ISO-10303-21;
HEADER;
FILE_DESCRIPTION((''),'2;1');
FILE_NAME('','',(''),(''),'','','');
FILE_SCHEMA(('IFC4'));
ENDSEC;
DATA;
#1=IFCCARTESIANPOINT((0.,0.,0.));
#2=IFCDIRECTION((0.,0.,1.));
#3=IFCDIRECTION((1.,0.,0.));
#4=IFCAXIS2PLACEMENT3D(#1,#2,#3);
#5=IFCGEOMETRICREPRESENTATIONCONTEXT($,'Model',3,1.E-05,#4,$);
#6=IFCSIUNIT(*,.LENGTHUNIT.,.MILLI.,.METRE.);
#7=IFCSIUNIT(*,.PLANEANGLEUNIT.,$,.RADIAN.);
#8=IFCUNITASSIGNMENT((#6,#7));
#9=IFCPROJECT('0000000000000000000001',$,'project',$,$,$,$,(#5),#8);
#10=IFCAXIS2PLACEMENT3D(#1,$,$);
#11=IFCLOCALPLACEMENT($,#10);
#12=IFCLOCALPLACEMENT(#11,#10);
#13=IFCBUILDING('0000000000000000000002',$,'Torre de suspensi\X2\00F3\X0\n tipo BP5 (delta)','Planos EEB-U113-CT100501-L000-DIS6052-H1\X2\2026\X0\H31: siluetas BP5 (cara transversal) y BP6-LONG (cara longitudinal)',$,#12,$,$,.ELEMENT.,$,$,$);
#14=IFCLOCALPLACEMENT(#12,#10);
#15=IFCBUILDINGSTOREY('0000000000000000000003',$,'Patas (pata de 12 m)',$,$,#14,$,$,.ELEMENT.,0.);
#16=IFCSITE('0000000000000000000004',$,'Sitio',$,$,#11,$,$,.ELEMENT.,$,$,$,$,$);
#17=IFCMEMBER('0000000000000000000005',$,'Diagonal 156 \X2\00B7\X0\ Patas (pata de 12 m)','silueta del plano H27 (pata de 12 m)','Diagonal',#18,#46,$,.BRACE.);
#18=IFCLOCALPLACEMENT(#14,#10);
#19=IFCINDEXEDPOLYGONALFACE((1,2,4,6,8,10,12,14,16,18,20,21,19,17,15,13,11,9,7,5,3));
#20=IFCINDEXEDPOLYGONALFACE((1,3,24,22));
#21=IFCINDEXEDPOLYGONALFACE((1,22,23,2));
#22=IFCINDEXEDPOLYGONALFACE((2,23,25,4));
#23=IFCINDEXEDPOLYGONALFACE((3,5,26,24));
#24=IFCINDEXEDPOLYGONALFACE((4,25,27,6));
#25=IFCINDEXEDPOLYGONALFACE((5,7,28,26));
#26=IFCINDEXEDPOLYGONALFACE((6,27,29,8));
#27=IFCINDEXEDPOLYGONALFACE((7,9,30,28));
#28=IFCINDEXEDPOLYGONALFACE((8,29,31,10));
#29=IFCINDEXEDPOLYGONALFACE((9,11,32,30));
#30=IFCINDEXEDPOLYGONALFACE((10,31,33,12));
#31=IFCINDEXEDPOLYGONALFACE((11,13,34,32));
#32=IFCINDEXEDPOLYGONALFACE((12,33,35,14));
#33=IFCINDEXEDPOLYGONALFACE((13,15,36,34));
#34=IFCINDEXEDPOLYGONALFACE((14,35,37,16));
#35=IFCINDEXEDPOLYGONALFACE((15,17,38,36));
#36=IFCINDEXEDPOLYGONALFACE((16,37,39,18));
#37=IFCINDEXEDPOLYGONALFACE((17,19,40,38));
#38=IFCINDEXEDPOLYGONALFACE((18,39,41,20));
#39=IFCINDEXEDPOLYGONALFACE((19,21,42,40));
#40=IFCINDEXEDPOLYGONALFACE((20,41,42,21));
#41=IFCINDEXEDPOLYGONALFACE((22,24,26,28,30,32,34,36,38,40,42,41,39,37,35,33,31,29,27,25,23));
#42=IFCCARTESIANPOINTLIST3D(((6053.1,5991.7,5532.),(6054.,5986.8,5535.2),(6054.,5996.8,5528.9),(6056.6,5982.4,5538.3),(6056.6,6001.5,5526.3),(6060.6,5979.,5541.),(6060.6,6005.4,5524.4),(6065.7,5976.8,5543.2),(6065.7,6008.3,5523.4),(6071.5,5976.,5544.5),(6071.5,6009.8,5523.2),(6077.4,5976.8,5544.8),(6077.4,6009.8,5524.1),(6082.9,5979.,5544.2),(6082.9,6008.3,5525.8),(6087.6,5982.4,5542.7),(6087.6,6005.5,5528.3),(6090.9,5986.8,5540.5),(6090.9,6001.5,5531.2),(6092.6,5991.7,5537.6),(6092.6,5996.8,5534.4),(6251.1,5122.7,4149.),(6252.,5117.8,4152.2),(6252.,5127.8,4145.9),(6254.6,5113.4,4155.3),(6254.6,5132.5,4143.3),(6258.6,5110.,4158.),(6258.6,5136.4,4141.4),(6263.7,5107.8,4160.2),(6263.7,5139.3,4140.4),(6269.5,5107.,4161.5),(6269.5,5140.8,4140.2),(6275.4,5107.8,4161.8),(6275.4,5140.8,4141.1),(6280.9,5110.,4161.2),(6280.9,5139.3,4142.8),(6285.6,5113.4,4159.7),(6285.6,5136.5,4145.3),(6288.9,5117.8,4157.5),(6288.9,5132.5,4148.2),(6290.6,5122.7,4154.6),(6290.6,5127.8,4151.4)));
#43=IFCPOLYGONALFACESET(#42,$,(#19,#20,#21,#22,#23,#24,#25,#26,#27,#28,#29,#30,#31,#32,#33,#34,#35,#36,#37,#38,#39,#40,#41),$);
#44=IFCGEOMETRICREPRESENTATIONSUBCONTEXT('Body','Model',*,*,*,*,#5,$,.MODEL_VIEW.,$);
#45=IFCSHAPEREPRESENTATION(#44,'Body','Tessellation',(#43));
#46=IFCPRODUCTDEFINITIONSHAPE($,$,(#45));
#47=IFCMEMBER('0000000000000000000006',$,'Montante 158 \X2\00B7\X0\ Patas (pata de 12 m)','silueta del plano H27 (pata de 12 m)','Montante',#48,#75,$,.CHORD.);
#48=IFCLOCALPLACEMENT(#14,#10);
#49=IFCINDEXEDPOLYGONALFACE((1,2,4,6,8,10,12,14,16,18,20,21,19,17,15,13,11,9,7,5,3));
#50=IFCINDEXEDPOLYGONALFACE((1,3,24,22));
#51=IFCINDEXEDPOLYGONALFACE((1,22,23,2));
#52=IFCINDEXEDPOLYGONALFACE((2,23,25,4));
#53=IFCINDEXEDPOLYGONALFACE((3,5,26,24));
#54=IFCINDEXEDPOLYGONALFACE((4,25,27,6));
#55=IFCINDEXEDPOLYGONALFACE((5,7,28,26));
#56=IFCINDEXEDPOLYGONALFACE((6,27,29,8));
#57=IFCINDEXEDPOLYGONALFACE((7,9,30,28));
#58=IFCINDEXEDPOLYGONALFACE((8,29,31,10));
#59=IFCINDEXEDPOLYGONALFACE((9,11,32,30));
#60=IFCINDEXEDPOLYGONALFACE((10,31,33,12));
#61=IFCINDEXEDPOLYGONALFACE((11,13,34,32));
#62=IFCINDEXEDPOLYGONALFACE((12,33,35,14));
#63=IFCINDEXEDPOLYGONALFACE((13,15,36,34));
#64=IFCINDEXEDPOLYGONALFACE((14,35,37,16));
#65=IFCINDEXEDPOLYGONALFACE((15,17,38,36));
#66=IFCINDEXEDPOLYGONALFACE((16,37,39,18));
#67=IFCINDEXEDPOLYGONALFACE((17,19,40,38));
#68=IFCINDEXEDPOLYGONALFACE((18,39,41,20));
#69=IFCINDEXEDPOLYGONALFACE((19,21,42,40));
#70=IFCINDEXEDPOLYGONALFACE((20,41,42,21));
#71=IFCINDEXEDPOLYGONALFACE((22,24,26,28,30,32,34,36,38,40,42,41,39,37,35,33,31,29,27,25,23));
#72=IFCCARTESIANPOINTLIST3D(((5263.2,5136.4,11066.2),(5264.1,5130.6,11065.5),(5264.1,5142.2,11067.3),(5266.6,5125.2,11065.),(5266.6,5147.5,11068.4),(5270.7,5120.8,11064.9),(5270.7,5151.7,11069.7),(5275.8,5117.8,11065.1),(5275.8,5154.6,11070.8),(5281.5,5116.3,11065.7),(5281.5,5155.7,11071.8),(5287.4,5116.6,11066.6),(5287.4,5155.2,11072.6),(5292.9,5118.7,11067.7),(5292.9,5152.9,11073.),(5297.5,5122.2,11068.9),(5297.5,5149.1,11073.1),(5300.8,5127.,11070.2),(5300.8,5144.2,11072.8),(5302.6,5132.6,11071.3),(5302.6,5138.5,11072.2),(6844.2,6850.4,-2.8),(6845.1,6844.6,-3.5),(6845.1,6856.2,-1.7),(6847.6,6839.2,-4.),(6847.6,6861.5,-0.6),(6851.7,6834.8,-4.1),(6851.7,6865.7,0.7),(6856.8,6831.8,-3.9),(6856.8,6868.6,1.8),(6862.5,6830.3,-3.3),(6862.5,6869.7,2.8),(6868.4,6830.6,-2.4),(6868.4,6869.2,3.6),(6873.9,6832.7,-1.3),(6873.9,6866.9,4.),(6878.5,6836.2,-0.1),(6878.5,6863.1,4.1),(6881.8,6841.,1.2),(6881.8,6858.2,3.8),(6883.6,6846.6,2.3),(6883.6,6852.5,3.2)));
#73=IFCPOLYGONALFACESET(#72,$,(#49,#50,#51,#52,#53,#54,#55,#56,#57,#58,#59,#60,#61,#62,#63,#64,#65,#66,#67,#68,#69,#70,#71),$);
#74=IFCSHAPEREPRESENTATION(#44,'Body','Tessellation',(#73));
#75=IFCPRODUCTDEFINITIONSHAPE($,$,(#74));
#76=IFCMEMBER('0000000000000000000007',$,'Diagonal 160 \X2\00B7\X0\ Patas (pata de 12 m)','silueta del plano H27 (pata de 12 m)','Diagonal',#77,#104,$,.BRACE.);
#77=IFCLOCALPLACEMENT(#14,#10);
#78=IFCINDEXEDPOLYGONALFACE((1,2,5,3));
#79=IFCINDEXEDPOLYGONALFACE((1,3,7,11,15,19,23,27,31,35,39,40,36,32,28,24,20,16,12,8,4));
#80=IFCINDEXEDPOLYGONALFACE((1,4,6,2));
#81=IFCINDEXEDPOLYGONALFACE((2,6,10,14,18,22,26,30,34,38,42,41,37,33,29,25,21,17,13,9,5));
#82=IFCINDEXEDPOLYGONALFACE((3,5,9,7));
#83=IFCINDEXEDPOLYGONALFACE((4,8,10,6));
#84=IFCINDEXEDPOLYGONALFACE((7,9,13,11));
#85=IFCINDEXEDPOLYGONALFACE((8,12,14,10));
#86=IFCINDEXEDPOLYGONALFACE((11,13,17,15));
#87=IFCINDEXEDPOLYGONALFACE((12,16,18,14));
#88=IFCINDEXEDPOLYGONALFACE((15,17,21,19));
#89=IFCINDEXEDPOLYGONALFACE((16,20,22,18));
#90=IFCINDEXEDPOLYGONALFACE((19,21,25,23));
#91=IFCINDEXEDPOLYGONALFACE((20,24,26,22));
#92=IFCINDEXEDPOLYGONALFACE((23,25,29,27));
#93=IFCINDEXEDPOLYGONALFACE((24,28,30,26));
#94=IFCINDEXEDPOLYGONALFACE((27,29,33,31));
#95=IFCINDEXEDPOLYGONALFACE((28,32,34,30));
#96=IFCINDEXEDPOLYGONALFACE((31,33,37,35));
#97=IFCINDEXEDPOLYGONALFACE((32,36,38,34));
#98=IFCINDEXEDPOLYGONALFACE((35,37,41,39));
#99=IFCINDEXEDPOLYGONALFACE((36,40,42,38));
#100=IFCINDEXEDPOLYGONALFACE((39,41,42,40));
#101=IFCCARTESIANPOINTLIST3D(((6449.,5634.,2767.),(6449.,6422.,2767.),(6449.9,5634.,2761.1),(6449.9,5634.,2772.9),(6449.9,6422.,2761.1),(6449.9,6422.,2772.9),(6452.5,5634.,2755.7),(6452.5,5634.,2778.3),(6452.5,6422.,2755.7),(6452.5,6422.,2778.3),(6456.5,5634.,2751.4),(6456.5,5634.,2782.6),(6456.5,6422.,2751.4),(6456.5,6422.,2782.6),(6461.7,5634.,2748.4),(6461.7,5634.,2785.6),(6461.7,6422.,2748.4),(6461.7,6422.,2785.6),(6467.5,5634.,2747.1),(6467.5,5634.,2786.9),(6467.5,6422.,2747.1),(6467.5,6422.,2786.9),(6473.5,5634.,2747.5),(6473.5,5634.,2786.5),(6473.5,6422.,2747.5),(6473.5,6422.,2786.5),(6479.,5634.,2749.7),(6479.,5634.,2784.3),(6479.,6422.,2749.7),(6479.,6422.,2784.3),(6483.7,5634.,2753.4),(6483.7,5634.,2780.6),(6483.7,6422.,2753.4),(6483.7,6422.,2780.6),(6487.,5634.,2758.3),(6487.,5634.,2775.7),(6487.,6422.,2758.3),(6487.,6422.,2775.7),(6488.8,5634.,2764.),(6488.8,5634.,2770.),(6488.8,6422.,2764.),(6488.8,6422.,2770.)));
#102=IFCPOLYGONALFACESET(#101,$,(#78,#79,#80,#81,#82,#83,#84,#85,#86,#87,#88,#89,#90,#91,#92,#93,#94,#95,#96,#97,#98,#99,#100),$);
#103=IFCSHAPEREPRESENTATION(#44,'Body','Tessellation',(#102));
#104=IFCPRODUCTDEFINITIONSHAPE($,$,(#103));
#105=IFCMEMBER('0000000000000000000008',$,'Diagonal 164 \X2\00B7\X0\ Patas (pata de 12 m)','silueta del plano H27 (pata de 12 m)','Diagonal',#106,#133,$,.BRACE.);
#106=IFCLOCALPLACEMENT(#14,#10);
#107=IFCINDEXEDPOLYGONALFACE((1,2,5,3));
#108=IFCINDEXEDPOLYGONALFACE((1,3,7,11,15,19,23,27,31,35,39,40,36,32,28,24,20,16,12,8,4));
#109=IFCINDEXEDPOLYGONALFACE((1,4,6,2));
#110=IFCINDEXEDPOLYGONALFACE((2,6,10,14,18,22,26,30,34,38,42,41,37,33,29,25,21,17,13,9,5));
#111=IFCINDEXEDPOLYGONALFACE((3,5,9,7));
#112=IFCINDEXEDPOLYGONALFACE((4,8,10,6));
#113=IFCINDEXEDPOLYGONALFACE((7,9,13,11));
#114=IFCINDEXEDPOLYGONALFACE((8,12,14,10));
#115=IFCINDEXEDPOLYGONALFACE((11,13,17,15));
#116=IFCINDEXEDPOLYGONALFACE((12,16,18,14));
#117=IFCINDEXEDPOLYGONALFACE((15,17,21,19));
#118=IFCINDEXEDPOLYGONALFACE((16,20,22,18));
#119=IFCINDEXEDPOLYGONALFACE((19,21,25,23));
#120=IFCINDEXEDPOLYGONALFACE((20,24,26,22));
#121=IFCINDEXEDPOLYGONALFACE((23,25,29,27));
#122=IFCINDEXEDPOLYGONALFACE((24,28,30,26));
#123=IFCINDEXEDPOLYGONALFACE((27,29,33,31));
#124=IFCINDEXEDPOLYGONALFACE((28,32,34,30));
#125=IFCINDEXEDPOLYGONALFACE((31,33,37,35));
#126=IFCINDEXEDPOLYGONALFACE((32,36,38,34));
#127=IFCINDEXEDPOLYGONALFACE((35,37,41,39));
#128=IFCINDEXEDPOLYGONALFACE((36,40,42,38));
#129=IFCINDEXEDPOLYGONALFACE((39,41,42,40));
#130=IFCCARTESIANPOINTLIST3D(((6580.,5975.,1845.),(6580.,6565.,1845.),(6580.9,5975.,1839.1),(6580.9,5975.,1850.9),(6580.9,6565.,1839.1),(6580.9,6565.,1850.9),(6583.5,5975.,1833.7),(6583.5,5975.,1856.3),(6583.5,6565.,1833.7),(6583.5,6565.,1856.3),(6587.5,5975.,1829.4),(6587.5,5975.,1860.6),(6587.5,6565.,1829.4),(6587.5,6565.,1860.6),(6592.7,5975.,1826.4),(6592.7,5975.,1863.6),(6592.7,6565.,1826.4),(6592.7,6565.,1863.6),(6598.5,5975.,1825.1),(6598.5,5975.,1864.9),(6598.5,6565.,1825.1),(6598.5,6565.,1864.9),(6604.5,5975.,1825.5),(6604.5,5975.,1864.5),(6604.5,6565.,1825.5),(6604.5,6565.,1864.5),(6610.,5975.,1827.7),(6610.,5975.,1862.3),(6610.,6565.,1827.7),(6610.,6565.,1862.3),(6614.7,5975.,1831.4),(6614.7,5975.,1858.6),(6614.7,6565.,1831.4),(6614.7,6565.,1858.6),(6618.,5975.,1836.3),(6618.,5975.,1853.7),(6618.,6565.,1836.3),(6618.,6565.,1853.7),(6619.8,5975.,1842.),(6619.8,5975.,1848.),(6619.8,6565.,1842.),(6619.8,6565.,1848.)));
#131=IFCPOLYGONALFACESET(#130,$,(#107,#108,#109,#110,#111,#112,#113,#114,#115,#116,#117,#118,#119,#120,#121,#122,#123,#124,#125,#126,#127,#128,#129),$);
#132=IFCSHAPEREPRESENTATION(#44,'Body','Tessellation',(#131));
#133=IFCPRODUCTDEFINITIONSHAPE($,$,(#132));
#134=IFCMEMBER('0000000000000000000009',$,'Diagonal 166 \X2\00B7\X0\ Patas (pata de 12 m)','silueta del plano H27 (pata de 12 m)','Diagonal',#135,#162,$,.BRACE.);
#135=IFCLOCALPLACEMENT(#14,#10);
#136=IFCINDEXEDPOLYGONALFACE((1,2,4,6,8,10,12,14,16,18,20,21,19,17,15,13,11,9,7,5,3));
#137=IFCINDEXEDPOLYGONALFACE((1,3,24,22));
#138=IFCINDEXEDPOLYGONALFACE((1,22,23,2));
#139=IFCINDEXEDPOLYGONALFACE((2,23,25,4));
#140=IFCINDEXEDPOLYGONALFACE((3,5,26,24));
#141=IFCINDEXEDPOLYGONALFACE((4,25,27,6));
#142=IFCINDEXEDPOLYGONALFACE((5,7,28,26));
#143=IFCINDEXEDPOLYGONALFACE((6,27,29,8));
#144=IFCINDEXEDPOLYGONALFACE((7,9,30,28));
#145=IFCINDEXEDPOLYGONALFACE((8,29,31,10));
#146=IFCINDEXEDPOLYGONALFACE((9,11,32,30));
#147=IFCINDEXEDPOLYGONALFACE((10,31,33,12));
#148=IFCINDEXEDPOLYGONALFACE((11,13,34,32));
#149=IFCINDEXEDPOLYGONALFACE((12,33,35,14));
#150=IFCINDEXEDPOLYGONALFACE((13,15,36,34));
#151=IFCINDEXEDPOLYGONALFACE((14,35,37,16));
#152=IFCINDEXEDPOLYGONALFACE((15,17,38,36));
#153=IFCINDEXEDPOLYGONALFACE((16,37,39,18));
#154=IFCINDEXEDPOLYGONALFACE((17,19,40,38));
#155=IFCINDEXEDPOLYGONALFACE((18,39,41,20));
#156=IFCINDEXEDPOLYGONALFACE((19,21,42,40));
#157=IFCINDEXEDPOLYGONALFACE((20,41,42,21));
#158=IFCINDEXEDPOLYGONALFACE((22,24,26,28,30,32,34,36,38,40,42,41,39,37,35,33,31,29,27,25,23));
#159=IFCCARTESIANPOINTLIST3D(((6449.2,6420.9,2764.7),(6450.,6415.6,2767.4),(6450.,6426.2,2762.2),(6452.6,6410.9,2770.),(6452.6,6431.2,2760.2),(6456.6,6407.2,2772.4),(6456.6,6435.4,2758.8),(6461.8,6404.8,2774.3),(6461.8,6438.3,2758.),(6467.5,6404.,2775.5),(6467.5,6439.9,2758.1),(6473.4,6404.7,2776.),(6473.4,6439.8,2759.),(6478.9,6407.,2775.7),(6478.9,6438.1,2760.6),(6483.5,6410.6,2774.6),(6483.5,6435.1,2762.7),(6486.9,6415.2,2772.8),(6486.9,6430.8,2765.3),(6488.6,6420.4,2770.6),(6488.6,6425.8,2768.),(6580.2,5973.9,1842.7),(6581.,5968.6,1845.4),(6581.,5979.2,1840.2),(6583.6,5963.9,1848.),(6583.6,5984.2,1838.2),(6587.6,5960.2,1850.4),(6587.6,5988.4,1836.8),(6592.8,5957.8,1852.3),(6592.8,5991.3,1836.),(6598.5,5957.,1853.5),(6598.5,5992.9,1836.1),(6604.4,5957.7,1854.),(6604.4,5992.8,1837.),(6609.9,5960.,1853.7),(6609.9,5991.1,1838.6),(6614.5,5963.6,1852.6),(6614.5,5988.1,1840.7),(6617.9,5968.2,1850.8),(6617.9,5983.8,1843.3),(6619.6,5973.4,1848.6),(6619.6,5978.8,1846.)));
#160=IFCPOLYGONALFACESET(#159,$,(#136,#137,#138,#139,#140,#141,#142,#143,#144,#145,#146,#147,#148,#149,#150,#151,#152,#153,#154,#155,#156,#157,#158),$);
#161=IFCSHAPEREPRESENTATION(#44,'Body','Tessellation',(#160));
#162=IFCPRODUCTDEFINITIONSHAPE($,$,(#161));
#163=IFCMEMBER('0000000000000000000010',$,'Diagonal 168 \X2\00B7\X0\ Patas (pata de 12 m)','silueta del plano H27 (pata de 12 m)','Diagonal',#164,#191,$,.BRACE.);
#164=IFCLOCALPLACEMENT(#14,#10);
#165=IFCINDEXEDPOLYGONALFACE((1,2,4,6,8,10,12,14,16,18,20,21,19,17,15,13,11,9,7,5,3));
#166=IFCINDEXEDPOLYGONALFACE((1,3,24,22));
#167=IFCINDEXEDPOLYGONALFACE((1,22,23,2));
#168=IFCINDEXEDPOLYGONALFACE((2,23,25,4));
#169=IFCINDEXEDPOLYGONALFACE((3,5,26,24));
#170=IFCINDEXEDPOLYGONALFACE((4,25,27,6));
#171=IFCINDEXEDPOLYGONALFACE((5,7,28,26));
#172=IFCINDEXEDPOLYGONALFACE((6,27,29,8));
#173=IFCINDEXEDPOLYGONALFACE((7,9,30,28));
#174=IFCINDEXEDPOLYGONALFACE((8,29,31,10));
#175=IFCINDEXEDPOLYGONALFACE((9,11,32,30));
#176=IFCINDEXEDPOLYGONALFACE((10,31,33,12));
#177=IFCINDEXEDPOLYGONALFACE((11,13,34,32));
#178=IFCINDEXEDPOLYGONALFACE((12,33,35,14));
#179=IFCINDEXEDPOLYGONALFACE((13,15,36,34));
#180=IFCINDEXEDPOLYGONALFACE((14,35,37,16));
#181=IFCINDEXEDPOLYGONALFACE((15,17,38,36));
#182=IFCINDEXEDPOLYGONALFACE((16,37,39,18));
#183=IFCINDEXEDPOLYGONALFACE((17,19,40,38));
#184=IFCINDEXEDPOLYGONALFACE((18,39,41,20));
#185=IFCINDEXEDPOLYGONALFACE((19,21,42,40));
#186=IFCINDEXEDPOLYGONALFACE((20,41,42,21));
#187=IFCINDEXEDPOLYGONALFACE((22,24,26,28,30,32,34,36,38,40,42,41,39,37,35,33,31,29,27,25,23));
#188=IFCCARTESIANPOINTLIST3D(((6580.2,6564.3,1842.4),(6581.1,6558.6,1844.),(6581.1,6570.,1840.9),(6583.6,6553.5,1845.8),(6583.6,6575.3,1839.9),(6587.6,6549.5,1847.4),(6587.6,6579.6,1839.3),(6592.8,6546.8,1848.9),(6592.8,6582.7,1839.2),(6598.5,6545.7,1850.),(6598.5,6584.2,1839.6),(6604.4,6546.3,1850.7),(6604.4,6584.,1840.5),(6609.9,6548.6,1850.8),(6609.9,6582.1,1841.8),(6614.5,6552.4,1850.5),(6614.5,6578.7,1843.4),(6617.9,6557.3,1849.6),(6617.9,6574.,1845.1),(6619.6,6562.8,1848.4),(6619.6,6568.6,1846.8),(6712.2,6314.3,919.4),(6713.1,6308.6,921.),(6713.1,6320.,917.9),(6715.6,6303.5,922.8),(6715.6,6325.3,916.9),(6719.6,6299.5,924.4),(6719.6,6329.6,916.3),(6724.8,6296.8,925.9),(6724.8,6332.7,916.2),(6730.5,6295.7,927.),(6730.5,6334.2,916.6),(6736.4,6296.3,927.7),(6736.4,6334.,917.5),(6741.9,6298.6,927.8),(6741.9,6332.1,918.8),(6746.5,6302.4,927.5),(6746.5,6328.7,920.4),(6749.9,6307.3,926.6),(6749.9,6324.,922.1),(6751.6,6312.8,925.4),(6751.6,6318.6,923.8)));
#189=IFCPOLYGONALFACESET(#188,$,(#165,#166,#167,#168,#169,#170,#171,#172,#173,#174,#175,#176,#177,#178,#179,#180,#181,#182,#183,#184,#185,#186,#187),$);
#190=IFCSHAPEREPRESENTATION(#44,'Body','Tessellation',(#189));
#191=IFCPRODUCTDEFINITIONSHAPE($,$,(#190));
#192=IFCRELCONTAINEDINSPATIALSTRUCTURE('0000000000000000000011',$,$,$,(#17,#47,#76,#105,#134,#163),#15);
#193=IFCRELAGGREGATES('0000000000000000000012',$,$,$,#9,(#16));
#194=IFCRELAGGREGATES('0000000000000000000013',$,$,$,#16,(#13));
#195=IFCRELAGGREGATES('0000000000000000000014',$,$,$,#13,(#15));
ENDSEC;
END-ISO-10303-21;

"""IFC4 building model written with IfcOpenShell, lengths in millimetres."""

from ifc_helpers import new_model, si_unit, frame, origin, origin_with_axes, place, context, subcontext, project, spatial, circle, extrude, element, save


model = new_model("IFC4")

# Units and contexts
model_context = context("Model", 3, precision=1e-05, world=origin_with_axes())
body_context = subcontext(model_context, "Body", "Model", "MODEL_VIEW")
ifc_project = project(units=[si_unit("LENGTHUNIT", "METRE", prefix="MILLI"), si_unit("PLANEANGLEUNIT", "RADIAN")], contexts=[model_context])

# Site, building, storey
site_placement = place(None, origin())
site = spatial("IfcSite", under=ifc_project, at=site_placement, Name="Sitio", CompositionType="ELEMENT")
building_placement = place(site_placement, origin())
building = spatial("IfcBuilding", under=site, at=building_placement, Name="Torre de suspensión tipo BP5 (delta)", Description="Planos EEB-U113-CT100501-L000-DIS6052-H1…H31: siluetas BP5 (cara transversal) y BP6-LONG (cara longitudinal)", CompositionType="ELEMENT")
storey_placement = place(building_placement, origin())
storey = spatial("IfcBuildingStorey", under=building, at=storey_placement, Name="Patas (pata de 12 m)", CompositionType="ELEMENT", Elevation=0.0)

# Members
member_1_placement = place(storey_placement, frame((6271.0, 5124.0, 4151.0), z_axis=(-0.120342, 0.528167, 0.84057), x_axis=(-0.992733, -0.064026, -0.101896)))
element("IfcMember", 1, at=member_1_placement, inside=storey, Name="Diagonal 156 · Patas (pata de 12 m)", Description="silueta del plano H27 (pata de 12 m)", ObjectType="Diagonal", PredefinedType="BRACE", context=body_context, shape_type="SweptSolid", body=[
    extrude(circle(Radius=20.0), None, (0.0, 0.0, 1.0), 1645.3),
])
member_2_placement = place(storey_placement, frame((6864.0, 6850.0, 0.0), z_axis=(-0.139764, -0.151521, 0.978523), x_axis=(-0.990185, 0.021387, -0.138118)))
element("IfcMember", 2, at=member_2_placement, inside=storey, Name="Montante 158 · Patas (pata de 12 m)", Description="silueta del plano H27 (pata de 12 m)", ObjectType="Montante", PredefinedType="CHORD", context=body_context, shape_type="SweptSolid", body=[
    extrude(circle(Radius=20.0), None, (0.0, 0.0, 1.0), 11311.9),
])
member_3_placement = place(storey_placement, frame((6469.0, 6422.0, 2767.0), z_axis=(0.0, -1.0, 0.0), x_axis=(-1.0, 0.0, 0.0)))
element("IfcMember", 3, at=member_3_placement, inside=storey, Name="Diagonal 160 · Patas (pata de 12 m)", Description="silueta del plano H27 (pata de 12 m)", ObjectType="Diagonal", PredefinedType="BRACE", context=body_context, shape_type="SweptSolid", body=[
    extrude(circle(Radius=20.0), None, (0.0, 0.0, 1.0), 788.0),
])
member_4_placement = place(storey_placement, frame((6600.0, 6565.0, 1845.0), z_axis=(0.0, -1.0, 0.0), x_axis=(-1.0, 0.0, 0.0)))
element("IfcMember", 4, at=member_4_placement, inside=storey, Name="Diagonal 164 · Patas (pata de 12 m)", Description="silueta del plano H27 (pata de 12 m)", ObjectType="Diagonal", PredefinedType="BRACE", context=body_context, shape_type="SweptSolid", body=[
    extrude(circle(Radius=20.0), None, (0.0, 0.0, 1.0), 590.0),
])
member_5_placement = place(storey_placement, frame((6600.0, 5975.0, 1845.0), z_axis=(-0.126817, 0.432727, 0.892561), x_axis=(-0.991926, -0.055324, -0.114113)))
element("IfcMember", 5, at=member_5_placement, inside=storey, Name="Diagonal 166 · Patas (pata de 12 m)", Description="silueta del plano H27 (pata de 12 m)", ObjectType="Diagonal", PredefinedType="BRACE", context=body_context, shape_type="SweptSolid", body=[
    extrude(circle(Radius=20.0), None, (0.0, 0.0, 1.0), 1033.0),
])
member_6_placement = place(storey_placement, frame((6732.0, 6315.0, 922.0), z_axis=(-0.136741, 0.25898, 0.956154), x_axis=(-0.990607, -0.035749, -0.131986)))
element("IfcMember", 6, at=member_6_placement, inside=storey, Name="Diagonal 168 · Patas (pata de 12 m)", Description="silueta del plano H27 (pata de 12 m)", ObjectType="Diagonal", PredefinedType="BRACE", context=body_context, shape_type="SweptSolid", body=[
    extrude(circle(Radius=20.0), None, (0.0, 0.0, 1.0), 965.3),
])

save(model, "model.ifc")
